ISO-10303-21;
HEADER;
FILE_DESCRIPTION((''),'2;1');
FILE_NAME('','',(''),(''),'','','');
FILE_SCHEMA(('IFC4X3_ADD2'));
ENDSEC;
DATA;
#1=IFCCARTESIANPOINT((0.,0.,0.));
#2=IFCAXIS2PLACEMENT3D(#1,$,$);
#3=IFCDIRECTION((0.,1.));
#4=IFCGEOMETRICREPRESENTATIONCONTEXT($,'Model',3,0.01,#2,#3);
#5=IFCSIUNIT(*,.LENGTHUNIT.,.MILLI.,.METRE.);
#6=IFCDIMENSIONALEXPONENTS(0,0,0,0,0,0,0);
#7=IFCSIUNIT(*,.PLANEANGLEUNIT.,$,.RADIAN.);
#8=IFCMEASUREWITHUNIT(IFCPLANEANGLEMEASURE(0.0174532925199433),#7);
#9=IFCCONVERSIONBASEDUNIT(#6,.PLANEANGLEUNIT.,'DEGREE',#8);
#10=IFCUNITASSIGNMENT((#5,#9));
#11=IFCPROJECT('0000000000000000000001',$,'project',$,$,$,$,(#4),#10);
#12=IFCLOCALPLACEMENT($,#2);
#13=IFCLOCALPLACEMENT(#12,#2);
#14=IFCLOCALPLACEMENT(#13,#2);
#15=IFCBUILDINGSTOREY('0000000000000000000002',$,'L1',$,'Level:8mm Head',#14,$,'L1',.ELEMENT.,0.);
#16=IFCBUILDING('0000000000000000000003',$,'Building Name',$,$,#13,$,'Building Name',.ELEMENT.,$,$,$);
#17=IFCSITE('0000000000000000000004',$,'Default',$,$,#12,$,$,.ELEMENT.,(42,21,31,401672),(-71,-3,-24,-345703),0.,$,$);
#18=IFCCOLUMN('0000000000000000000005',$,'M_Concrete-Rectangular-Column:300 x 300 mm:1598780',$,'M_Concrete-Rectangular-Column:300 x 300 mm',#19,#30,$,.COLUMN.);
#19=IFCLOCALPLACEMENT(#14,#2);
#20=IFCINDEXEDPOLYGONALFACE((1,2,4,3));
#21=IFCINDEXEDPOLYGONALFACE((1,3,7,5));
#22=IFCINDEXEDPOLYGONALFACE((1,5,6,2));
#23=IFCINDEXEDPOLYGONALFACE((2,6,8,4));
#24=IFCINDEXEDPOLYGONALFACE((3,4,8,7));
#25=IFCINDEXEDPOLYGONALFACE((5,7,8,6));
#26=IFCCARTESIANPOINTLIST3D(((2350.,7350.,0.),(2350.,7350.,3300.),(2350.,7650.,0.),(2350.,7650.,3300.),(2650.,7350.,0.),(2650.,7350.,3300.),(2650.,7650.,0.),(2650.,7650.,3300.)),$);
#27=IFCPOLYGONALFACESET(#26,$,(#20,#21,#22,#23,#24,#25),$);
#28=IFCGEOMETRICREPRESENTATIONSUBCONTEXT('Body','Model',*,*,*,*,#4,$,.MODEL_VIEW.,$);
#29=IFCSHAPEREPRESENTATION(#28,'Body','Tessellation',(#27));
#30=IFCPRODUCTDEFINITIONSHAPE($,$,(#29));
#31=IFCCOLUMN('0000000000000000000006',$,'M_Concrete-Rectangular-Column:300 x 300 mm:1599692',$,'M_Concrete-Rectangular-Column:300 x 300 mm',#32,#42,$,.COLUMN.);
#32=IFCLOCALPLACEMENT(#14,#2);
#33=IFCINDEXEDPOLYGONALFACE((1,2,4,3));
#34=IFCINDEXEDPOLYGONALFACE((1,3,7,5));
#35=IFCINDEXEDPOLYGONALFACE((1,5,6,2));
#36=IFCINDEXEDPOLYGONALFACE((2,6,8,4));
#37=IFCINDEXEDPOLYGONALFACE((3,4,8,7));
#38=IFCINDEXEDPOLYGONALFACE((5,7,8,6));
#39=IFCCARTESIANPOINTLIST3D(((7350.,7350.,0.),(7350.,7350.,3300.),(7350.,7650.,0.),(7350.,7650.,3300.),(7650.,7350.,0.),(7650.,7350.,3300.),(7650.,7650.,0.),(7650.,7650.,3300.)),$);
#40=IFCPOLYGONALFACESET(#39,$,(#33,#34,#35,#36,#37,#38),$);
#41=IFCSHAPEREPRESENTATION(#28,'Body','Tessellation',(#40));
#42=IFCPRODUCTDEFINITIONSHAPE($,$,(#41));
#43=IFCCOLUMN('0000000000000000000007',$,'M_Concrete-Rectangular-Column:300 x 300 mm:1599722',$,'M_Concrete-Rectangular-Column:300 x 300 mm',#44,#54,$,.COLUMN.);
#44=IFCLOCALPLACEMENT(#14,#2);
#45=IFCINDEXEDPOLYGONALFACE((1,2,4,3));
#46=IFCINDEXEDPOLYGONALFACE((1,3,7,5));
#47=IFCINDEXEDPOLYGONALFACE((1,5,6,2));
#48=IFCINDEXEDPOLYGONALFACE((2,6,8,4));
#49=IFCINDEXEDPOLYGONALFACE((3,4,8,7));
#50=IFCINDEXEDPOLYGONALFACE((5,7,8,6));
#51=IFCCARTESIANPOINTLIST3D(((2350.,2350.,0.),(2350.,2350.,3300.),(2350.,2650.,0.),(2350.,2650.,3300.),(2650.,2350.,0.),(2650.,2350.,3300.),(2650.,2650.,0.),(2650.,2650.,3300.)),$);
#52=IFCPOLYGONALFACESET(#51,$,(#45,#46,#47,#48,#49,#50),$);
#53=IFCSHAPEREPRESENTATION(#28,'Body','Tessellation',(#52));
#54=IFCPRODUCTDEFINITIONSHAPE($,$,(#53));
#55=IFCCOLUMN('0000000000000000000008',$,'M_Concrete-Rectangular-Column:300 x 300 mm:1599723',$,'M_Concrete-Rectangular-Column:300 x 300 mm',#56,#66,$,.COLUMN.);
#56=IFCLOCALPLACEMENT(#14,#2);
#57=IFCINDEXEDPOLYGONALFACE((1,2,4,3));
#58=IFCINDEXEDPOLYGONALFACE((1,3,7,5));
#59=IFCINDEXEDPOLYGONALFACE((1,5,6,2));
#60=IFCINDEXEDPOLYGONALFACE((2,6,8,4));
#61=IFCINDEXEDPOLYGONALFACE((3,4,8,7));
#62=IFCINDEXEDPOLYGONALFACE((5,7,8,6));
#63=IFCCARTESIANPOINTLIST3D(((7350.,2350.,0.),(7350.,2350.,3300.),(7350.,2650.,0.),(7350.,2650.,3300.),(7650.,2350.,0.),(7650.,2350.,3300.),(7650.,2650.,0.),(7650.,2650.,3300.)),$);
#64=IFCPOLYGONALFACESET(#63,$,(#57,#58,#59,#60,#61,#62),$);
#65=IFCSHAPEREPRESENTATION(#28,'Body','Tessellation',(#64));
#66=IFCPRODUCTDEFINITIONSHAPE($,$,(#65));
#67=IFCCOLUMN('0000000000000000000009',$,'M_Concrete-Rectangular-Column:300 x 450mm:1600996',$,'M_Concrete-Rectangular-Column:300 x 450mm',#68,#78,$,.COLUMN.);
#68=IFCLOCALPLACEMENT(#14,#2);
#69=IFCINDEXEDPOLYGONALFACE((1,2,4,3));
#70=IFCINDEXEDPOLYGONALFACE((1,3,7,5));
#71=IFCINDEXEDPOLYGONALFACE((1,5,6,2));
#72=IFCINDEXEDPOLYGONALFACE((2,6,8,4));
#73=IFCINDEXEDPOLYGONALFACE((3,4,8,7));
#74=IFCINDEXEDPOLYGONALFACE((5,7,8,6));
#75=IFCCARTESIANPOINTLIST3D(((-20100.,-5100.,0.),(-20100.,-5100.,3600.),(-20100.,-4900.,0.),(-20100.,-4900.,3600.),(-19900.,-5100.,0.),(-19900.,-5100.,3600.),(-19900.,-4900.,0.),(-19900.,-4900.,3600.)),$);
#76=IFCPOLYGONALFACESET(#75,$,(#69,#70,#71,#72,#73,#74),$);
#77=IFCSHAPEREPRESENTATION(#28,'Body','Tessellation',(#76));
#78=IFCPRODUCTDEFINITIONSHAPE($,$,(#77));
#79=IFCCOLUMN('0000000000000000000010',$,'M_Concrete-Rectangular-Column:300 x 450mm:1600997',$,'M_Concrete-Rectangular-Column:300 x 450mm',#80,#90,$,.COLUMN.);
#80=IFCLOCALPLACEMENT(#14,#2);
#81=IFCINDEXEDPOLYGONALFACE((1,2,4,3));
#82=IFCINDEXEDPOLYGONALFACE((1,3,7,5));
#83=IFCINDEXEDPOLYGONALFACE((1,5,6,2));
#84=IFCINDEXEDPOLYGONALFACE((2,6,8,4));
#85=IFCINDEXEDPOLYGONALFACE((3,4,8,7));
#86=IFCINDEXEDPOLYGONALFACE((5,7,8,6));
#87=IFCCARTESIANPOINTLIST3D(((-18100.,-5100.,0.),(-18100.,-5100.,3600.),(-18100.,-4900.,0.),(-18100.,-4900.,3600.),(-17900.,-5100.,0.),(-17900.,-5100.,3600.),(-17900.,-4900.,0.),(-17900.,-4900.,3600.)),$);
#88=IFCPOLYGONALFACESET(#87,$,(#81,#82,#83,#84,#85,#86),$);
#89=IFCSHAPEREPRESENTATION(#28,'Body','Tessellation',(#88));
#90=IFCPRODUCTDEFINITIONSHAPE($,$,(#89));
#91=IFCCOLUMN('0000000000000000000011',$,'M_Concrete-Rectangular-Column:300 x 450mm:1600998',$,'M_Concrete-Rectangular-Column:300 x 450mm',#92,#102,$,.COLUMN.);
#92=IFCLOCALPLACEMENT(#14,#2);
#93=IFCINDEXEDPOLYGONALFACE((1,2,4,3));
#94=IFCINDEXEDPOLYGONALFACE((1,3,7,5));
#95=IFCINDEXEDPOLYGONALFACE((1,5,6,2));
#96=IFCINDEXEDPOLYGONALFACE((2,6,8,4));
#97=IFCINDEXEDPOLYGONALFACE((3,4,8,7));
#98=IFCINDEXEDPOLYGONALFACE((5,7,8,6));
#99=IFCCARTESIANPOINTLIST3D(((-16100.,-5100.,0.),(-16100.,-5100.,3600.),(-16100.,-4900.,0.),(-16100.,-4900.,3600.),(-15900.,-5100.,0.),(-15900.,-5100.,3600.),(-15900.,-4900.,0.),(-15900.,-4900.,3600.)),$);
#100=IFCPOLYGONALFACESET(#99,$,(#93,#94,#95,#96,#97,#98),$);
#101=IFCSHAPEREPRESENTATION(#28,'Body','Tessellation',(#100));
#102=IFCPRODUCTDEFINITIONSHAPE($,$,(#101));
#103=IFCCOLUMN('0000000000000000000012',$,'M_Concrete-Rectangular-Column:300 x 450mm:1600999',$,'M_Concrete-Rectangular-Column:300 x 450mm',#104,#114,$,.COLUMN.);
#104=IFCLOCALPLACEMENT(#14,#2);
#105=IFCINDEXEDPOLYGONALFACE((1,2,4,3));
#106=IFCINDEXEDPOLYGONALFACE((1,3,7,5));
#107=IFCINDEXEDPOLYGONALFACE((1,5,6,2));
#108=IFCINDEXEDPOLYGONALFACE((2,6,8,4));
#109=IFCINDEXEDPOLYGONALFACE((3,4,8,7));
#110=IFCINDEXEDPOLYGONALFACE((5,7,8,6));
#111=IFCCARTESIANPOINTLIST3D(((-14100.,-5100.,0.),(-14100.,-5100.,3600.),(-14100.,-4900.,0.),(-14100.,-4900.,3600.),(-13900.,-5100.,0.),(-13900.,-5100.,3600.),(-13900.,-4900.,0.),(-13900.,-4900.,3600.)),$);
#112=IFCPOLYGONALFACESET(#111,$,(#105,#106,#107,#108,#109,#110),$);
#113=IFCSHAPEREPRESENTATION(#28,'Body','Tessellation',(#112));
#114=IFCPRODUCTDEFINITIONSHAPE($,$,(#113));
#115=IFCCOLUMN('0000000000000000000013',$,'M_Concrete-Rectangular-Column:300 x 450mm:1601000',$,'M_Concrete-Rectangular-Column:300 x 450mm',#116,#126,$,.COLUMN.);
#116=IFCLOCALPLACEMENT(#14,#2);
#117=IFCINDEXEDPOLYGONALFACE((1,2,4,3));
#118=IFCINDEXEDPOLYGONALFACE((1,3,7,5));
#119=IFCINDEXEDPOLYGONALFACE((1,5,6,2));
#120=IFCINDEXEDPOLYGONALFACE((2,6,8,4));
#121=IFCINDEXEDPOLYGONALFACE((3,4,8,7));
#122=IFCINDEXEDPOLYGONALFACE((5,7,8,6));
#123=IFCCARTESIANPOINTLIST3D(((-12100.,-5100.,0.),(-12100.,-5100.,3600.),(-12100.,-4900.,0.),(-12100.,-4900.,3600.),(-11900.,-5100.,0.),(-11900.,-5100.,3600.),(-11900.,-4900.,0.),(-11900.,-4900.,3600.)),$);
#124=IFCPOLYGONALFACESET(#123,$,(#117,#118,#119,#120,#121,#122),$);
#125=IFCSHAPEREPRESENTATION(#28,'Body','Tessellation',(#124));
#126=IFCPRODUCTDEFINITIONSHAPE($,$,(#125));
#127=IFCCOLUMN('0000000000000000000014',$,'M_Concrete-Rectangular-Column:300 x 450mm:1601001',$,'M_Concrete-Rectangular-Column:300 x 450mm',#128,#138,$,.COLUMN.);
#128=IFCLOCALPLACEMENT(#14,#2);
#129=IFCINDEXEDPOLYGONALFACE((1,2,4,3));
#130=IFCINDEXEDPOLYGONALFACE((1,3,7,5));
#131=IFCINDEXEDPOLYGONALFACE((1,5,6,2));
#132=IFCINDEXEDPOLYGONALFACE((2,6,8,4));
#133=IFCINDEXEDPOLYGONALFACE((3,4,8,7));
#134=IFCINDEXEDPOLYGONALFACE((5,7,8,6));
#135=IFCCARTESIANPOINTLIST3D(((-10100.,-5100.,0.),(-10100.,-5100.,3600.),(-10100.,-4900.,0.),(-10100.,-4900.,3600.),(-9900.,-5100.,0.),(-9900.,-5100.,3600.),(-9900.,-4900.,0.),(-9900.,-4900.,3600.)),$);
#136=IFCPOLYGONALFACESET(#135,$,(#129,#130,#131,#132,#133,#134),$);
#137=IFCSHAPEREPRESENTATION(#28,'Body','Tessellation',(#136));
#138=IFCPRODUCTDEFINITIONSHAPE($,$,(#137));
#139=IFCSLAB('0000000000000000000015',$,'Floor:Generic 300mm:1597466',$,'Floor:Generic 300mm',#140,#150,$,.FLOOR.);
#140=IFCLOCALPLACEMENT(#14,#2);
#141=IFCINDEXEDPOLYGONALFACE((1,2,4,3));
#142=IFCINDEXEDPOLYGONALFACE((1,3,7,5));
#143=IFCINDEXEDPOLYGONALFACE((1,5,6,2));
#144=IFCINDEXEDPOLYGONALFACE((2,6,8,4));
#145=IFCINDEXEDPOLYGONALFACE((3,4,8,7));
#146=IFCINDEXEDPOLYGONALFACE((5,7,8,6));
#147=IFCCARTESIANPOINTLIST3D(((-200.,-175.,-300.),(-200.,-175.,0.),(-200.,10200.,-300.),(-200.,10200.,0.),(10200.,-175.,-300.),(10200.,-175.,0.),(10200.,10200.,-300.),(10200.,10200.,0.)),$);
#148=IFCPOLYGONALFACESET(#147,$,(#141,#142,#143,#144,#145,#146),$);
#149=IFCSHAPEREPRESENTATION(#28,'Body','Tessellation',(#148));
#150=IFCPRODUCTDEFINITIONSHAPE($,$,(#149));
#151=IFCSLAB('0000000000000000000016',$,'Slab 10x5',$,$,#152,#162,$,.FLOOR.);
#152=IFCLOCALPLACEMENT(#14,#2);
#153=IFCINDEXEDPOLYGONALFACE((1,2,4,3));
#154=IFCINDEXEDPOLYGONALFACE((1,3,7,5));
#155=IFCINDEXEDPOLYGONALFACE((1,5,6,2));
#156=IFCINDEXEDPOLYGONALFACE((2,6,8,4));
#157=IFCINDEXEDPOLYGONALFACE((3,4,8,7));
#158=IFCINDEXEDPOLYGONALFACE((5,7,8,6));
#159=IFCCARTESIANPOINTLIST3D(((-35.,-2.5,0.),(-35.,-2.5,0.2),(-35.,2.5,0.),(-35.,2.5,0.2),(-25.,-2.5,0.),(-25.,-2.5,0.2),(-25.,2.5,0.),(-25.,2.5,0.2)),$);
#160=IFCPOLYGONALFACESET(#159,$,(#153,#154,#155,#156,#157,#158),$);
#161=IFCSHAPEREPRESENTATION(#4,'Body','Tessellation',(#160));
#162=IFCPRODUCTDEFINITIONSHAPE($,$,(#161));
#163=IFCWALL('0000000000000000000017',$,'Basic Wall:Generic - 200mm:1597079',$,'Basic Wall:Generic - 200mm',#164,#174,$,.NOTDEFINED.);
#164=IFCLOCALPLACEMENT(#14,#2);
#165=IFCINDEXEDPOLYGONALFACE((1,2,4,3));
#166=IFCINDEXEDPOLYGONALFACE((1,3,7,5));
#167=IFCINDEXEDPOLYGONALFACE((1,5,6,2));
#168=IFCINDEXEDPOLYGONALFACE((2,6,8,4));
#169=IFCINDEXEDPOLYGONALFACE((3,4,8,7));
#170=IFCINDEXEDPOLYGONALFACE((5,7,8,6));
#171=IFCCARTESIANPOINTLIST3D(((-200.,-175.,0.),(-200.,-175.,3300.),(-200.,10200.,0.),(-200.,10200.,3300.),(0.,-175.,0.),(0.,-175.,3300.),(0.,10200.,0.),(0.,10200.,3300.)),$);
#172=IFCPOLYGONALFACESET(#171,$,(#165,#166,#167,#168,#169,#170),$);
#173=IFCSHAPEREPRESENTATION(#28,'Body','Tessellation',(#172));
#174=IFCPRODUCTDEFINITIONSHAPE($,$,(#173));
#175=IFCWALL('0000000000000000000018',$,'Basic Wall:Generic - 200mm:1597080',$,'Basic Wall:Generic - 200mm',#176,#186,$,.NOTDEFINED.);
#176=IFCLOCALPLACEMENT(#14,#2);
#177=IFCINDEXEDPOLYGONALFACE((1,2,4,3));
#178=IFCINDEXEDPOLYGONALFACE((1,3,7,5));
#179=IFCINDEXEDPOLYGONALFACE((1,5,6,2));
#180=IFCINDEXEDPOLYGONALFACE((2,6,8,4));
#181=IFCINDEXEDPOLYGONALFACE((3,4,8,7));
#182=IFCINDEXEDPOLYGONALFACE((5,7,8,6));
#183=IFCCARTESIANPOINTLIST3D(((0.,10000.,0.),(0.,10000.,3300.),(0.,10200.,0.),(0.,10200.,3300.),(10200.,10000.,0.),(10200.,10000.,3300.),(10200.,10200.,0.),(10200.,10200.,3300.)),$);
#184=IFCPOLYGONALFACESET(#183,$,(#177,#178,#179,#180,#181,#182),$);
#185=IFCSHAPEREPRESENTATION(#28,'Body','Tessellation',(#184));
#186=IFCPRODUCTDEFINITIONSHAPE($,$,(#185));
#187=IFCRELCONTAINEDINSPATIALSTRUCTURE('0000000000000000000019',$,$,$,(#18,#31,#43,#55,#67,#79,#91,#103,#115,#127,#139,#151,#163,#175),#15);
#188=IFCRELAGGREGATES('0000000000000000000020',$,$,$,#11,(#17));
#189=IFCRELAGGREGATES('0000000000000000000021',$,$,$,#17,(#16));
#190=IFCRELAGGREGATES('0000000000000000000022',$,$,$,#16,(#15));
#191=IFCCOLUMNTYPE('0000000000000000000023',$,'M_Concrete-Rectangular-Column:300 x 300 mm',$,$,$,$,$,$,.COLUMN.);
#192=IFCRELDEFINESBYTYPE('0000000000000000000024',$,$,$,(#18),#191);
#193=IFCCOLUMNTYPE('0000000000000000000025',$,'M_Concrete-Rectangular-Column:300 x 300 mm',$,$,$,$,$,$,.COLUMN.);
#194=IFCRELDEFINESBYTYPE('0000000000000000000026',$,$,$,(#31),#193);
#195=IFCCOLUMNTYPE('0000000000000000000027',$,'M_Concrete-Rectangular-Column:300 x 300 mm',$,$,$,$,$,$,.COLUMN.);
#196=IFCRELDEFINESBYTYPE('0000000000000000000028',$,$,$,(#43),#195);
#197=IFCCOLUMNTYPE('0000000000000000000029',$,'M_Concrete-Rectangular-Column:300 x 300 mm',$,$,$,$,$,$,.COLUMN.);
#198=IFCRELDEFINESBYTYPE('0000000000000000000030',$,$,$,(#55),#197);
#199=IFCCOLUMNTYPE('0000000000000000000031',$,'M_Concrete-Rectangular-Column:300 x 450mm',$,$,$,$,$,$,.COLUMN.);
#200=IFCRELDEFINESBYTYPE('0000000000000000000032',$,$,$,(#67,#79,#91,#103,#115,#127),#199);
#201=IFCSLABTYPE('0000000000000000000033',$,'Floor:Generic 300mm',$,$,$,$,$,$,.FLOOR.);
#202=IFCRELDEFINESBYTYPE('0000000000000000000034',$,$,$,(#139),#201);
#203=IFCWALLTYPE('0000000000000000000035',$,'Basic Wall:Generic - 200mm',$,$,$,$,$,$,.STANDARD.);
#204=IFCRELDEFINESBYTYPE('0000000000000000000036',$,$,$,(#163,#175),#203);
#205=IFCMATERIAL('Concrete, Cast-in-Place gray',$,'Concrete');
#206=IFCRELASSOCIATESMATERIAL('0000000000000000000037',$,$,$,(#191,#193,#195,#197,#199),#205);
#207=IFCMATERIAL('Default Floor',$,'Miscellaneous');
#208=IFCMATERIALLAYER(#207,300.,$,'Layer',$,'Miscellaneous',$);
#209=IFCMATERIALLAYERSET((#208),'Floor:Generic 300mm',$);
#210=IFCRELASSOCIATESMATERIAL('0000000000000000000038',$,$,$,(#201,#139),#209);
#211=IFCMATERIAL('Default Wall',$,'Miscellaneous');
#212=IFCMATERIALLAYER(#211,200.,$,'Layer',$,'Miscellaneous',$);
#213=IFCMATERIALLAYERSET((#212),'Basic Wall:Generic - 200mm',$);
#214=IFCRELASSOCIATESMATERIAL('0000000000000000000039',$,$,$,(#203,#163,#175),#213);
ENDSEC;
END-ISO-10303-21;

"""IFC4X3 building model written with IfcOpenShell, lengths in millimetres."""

from ifc_helpers import new_model, entity, si_unit, converted_unit, direction, frame, frame_2d, origin, origin_2d_with_axis, place, context, subcontext, project, spatial, rectangle, extrude, source, transform, mapped, material, layer, layer_set, layer_usage, material_profile, profile_set, type_object, type_shapes, element, save


model = new_model("IFC4X3")

# Units and contexts
model_context = context("Model", 3, precision=0.01, world=origin(), true_north=direction((0.0, 1.0)))
body_context = subcontext(model_context, "Body", "Model", "MODEL_VIEW")
ifc_project = project(units=[si_unit("LENGTHUNIT", "METRE", prefix="MILLI"), converted_unit("PLANEANGLEUNIT", "DEGREE", entity("IfcPlaneAngleMeasure", 0.0174532925199433), si_unit("PLANEANGLEUNIT", "RADIAN"), dimensions=[0, 0, 0, 0, 0, 0, 0])], contexts=[model_context])

# Site, building, storey
site_placement = place(None, origin())
site = spatial("IfcSite", under=ifc_project, at=site_placement, Name="Default", CompositionType="ELEMENT", RefLatitude=(42, 21, 31, 401672), RefLongitude=(-71, -3, -24, -345703), RefElevation=0.0)
building_placement = place(site_placement, origin())
building = spatial("IfcBuilding", under=site, at=building_placement, Name="Building Name", LongName="Building Name", CompositionType="ELEMENT")
storey_placement = place(building_placement, origin())
storey = spatial("IfcBuildingStorey", under=building, at=storey_placement, Name="L1", ObjectType="Level:8mm Head", LongName="L1", CompositionType="ELEMENT", Elevation=0.0)

# Columns
ifc_material_1 = material(Name="Concrete, Cast-in-Place gray", Category="Concrete")
ifc_material_profile_1 = material_profile(ifc_material_1, rectangle(XDim=300.0, YDim=300.0, at=origin_2d_with_axis()), Name="300 x 300 mm")
ifc_profile_set_1 = profile_set([ifc_material_profile_1], Name="300 x 300 mm")
column_type_1 = type_object("IfcColumnType", Name="M_Concrete-Rectangular-Column:300 x 300 mm", PredefinedType="COLUMN", material=ifc_profile_set_1)
shared_shape_1 = source(origin(), body_context, "Body", "SweptSolid", [
    extrude(rectangle(XDim=300.0, YDim=300.0, at=origin_2d_with_axis()), frame((2500.0, 7500.0, 0.0)), (0.0, 0.0, 1.0), 3300.0),
])
type_shapes(column_type_1, [shared_shape_1])
column_1_placement = place(storey_placement, origin())
element("IfcColumn", 1, at=column_1_placement, inside=storey, type_object=column_type_1, Name="M_Concrete-Rectangular-Column:300 x 300 mm:1598780", ObjectType="M_Concrete-Rectangular-Column:300 x 300 mm", PredefinedType="COLUMN", context=body_context, shape_type="MappedRepresentation", body=[
    mapped(shared_shape_1, transform((0.0, 0.0, 0.0), scale=1.0)),
])
column_type_2 = type_object("IfcColumnType", Name="M_Concrete-Rectangular-Column:300 x 300 mm", PredefinedType="COLUMN", material=ifc_profile_set_1)
shared_shape_2 = source(origin(), body_context, "Body", "SweptSolid", [
    extrude(rectangle(XDim=300.0, YDim=300.0, at=origin_2d_with_axis()), frame((7500.0, 7500.0, 0.0)), (0.0, 0.0, 1.0), 3300.0),
])
type_shapes(column_type_2, [shared_shape_2])
column_2_placement = place(storey_placement, origin())
element("IfcColumn", 2, at=column_2_placement, inside=storey, type_object=column_type_2, Name="M_Concrete-Rectangular-Column:300 x 300 mm:1599692", ObjectType="M_Concrete-Rectangular-Column:300 x 300 mm", PredefinedType="COLUMN", context=body_context, shape_type="MappedRepresentation", body=[
    mapped(shared_shape_2, transform((0.0, 0.0, 0.0), scale=1.0)),
])
column_type_3 = type_object("IfcColumnType", Name="M_Concrete-Rectangular-Column:300 x 300 mm", PredefinedType="COLUMN", material=ifc_profile_set_1)
shared_shape_3 = source(origin(), body_context, "Body", "SweptSolid", [
    extrude(rectangle(XDim=300.0, YDim=300.0, at=origin_2d_with_axis()), frame((2500.0, 2500.0, 0.0)), (0.0, 0.0, 1.0), 3300.0),
])
type_shapes(column_type_3, [shared_shape_3])
column_3_placement = place(storey_placement, origin())
element("IfcColumn", 3, at=column_3_placement, inside=storey, type_object=column_type_3, Name="M_Concrete-Rectangular-Column:300 x 300 mm:1599722", ObjectType="M_Concrete-Rectangular-Column:300 x 300 mm", PredefinedType="COLUMN", context=body_context, shape_type="MappedRepresentation", body=[
    mapped(shared_shape_3, transform((0.0, 0.0, 0.0), scale=1.0)),
])
column_type_4 = type_object("IfcColumnType", Name="M_Concrete-Rectangular-Column:300 x 300 mm", PredefinedType="COLUMN", material=ifc_profile_set_1)
shared_shape_4 = source(origin(), body_context, "Body", "SweptSolid", [
    extrude(rectangle(XDim=300.0, YDim=300.0, at=origin_2d_with_axis()), frame((7500.0, 2500.0, 0.0)), (0.0, 0.0, 1.0), 3300.0),
])
type_shapes(column_type_4, [shared_shape_4])
column_4_placement = place(storey_placement, origin())
element("IfcColumn", 4, at=column_4_placement, inside=storey, type_object=column_type_4, Name="M_Concrete-Rectangular-Column:300 x 300 mm:1599723", ObjectType="M_Concrete-Rectangular-Column:300 x 300 mm", PredefinedType="COLUMN", context=body_context, shape_type="MappedRepresentation", body=[
    mapped(shared_shape_4, transform((0.0, 0.0, 0.0), scale=1.0)),
])
ifc_material_profile_2 = material_profile(ifc_material_1, rectangle(XDim=200.0, YDim=200.0, at=origin_2d_with_axis()), Name="300 x 450mm")
ifc_profile_set_2 = profile_set([ifc_material_profile_2], Name="300 x 450mm")
column_type_5 = type_object("IfcColumnType", Name="M_Concrete-Rectangular-Column:300 x 450mm", PredefinedType="COLUMN", material=ifc_profile_set_2)
shared_shape_5 = source(origin(), body_context, "Body", "SweptSolid", [
    extrude(rectangle(XDim=200.0, YDim=200.0, at=origin_2d_with_axis()), frame((0.0, 0.0, 0.0), z_axis=(0.0, 0.0, 1.0), x_axis=(-1.0, 0.0, 0.0)), (0.0, 0.0, 1.0), 3600.0),
])
type_shapes(column_type_5, [shared_shape_5])
for number, where, z_axis, x_axis, name in (
    (5, (-20000.0, -5000.0, 0.0), (0.0, 0.0, 1.0), (0.0, -1.0, 0.0), "M_Concrete-Rectangular-Column:300 x 450mm:1600996"),
    (6, (-18000.0, -5000.0, 0.0), (0.0, 0.0, 1.0), (0.0, -1.0, 0.0), "M_Concrete-Rectangular-Column:300 x 450mm:1600997"),
    (7, (-16000.0, -5000.0, 0.0), (0.0, 0.0, 1.0), (0.0, -1.0, 0.0), "M_Concrete-Rectangular-Column:300 x 450mm:1600998"),
    (8, (-14000.0, -5000.0, 0.0), (0.0, 0.0, 1.0), (0.0, -1.0, 0.0), "M_Concrete-Rectangular-Column:300 x 450mm:1600999"),
    (9, (-12000.0, -5000.0, 0.0), (0.0, 0.0, 1.0), (0.0, -1.0, 0.0), "M_Concrete-Rectangular-Column:300 x 450mm:1601000"),
    (10, (-10000.0, -5000.0, 0.0), (0.0, 0.0, 1.0), (0.0, -1.0, 0.0), "M_Concrete-Rectangular-Column:300 x 450mm:1601001"),
):
    element("IfcColumn", number, at=place(storey_placement, frame(where, z_axis=z_axis, x_axis=x_axis)), inside=storey, type_object=column_type_5, Name=name, ObjectType="M_Concrete-Rectangular-Column:300 x 450mm", PredefinedType="COLUMN", context=body_context, shape_type="MappedRepresentation", body=[
        mapped(shared_shape_5, transform((0.0, 0.0, 0.0), scale=1.0)),
    ])

# Slabs
ifc_material_2 = material(Name="Default Floor", Category="Miscellaneous")
ifc_layer_1 = layer(ifc_material_2, 300.0, Name="Layer", Category="Miscellaneous")
ifc_layer_set_1 = layer_set([ifc_layer_1], Name="Floor:Generic 300mm")
ifc_layer_usage = layer_usage(ifc_layer_set_1, "AXIS3", "POSITIVE", 0.0)
slab_type = type_object("IfcSlabType", Name="Floor:Generic 300mm", PredefinedType="FLOOR", material=ifc_layer_set_1)
slab_1_placement = place(storey_placement, origin())
element("IfcSlab", 11, at=slab_1_placement, inside=storey, type_object=slab_type, material=ifc_layer_usage, Name="Floor:Generic 300mm:1597466", ObjectType="Floor:Generic 300mm", PredefinedType="FLOOR", context=body_context, shape_type="SweptSolid", body=[
    extrude(rectangle(XDim=10375.0, YDim=10400.0, at=origin_2d_with_axis()), frame((5000.0, 5012.5, 0.0), z_axis=(0.0, 0.0, -1.0), x_axis=(0.0, 1.0, 0.0)), (0.0, 0.0, 1.0), 300.0),
])
slab_2_placement = place(None, frame((-30.0, 0.0, 0.0)))
element("IfcSlab", 12, at=slab_2_placement, inside=storey, Name="Slab 10x5", PredefinedType="FLOOR", context=model_context, shape_type="SweptSolid", body=[
    extrude(rectangle(XDim=10.0, YDim=5.0), None, (0.0, 0.0, 1.0), 0.2),
])

# Walls
ifc_material_3 = material(Name="Default Wall", Category="Miscellaneous")
ifc_layer_2 = layer(ifc_material_3, 200.0, Name="Layer", Category="Miscellaneous")
ifc_layer_set_2 = layer_set([ifc_layer_2], Name="Basic Wall:Generic - 200mm")
wall_type_1 = type_object("IfcWallType", Name="Basic Wall:Generic - 200mm", PredefinedType="STANDARD", material=ifc_layer_set_2)
wall_1_placement = place(storey_placement, frame((-100.0, 10200.0, 0.0), z_axis=(0.0, 0.0, 1.0), x_axis=(0.0, -1.0, 0.0)))
element("IfcWall", 13, at=wall_1_placement, inside=storey, type_object=wall_type_1, material=ifc_layer_set_2, Name="Basic Wall:Generic - 200mm:1597079", ObjectType="Basic Wall:Generic - 200mm", PredefinedType="NOTDEFINED", context=body_context, shape_type="SweptSolid", body=[
    extrude(rectangle(XDim=10375.0, YDim=200.0, at=frame_2d((5187.5, 0.0), x_axis=(-1.0, 0.0))), origin(), (0.0, 0.0, 1.0), 3300.0),
])
wall_2_placement = place(storey_placement, frame((10200.0, 10100.0, 0.0), z_axis=(0.0, 0.0, 1.0), x_axis=(-1.0, 0.0, 0.0)))
element("IfcWall", 14, at=wall_2_placement, inside=storey, type_object=wall_type_1, material=ifc_layer_set_2, Name="Basic Wall:Generic - 200mm:1597080", ObjectType="Basic Wall:Generic - 200mm", PredefinedType="NOTDEFINED", context=body_context, shape_type="SweptSolid", body=[
    extrude(rectangle(XDim=10200.0, YDim=200.0, at=frame_2d((5100.0, 0.0), x_axis=(-1.0, 0.0))), origin(), (0.0, 0.0, 1.0), 3300.0),
])

save(model, "model.ifc")
